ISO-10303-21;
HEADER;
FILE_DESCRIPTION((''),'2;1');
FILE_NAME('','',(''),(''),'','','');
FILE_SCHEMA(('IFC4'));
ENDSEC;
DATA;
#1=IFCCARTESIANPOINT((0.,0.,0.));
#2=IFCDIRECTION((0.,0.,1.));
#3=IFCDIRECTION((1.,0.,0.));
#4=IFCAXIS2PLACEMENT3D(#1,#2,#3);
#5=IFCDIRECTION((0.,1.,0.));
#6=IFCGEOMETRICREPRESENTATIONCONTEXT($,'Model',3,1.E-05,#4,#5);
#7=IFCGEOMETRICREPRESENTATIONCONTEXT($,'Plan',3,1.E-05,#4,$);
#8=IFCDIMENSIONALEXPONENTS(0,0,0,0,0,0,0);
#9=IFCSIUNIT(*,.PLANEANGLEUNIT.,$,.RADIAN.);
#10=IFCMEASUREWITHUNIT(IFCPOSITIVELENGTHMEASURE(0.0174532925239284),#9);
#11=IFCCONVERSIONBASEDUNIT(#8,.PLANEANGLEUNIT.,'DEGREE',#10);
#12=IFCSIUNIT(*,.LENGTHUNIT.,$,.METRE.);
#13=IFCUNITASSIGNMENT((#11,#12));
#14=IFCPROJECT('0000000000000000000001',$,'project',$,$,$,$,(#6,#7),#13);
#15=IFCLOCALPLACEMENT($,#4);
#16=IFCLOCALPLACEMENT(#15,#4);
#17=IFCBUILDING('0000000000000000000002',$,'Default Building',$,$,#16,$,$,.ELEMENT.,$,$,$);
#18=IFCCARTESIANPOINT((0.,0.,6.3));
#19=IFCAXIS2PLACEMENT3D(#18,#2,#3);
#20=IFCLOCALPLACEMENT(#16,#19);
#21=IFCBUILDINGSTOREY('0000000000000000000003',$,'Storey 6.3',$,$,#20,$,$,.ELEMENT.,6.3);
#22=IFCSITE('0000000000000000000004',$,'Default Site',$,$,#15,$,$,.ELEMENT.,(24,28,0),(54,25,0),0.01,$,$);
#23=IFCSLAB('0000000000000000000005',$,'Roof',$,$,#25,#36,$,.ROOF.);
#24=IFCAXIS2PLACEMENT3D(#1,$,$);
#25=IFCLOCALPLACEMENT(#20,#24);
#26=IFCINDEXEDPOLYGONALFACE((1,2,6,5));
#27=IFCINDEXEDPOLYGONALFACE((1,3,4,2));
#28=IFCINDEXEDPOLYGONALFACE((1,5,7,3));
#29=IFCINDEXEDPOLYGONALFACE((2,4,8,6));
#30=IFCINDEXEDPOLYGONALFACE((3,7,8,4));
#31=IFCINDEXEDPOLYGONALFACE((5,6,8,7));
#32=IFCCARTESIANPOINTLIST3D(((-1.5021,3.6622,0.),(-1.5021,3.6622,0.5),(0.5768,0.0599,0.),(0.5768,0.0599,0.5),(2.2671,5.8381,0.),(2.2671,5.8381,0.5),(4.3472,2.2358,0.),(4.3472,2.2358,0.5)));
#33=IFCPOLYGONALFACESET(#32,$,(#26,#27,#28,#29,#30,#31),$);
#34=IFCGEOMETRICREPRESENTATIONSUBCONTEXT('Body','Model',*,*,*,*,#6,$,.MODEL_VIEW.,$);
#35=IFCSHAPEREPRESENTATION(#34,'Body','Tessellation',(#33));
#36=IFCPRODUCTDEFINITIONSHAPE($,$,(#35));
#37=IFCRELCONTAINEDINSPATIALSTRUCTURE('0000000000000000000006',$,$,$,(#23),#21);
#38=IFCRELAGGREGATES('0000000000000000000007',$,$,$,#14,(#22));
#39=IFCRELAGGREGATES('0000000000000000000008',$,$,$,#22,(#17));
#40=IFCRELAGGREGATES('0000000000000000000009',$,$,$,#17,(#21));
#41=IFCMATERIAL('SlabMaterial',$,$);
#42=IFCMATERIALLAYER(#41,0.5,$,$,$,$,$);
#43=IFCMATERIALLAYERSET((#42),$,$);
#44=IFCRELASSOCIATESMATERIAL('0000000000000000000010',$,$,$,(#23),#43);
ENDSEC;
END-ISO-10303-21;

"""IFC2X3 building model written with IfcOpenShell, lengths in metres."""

from ifc_helpers import new_model, entity, si_unit, converted_unit, direction, frame, origin_with_axes, place, context, subcontext, project, spatial, polyline, outline, extrude, material, layer, layer_set, layer_usage, element, save


model = new_model("IFC2X3")

# Units and contexts
model_context = context("Model", 3, precision=1e-05, world=origin_with_axes(), true_north=direction((0.0, 1.0, 0.0)))
plan_context = context("Plan", 3, precision=1e-05, world=origin_with_axes())
body_context = subcontext(model_context, "Body", "Model", "MODEL_VIEW")
ifc_project = project(units=[converted_unit("PLANEANGLEUNIT", "DEGREE", entity("IfcPositiveLengthMeasure", 0.0174532925239284), si_unit("PLANEANGLEUNIT", "RADIAN"), dimensions=[0, 0, 0, 0, 0, 0, 0]), si_unit("LENGTHUNIT", "METRE")], contexts=[model_context, plan_context])

# Site, building, storey
site_placement = place(None, origin_with_axes())
site = spatial("IfcSite", under=ifc_project, at=site_placement, Name="Default Site", CompositionType="ELEMENT", RefLatitude=(24, 28, 0), RefLongitude=(54, 25, 0), RefElevation=0.01)
building_placement = place(site_placement, origin_with_axes())
building = spatial("IfcBuilding", under=site, at=building_placement, Name="Default Building", CompositionType="ELEMENT")
storey_placement = place(building_placement, frame((0.0, 0.0, 6.3), z_axis=(0.0, 0.0, 1.0), x_axis=(1.0, 0.0, 0.0)))
storey = spatial("IfcBuildingStorey", under=building, at=storey_placement, Name="Storey 6.3", CompositionType="ELEMENT", Elevation=6.3)

# Slab
ifc_material = material(Name="SlabMaterial")
ifc_layer = layer(ifc_material, 0.5)
ifc_layer_set = layer_set([ifc_layer])
ifc_layer_usage = layer_usage(ifc_layer_set, "AXIS2", "POSITIVE", 0.5)
slab_placement = place(storey_placement, origin_with_axes())
element("IfcSlab", 1, at=slab_placement, inside=storey, material=ifc_layer_usage, Name="Roof", PredefinedType="ROOF", context=body_context, shape_type="SweptSolid", body=[
    extrude(outline(polyline([(4.3472, 2.2358), (2.2671, 5.8381), (-1.5021, 3.6622), (0.5768, 0.0599), (4.3472, 2.2358)])), origin_with_axes(), (0.0, 0.0, 1.0), 0.5),
])

save(model, "model.ifc")
